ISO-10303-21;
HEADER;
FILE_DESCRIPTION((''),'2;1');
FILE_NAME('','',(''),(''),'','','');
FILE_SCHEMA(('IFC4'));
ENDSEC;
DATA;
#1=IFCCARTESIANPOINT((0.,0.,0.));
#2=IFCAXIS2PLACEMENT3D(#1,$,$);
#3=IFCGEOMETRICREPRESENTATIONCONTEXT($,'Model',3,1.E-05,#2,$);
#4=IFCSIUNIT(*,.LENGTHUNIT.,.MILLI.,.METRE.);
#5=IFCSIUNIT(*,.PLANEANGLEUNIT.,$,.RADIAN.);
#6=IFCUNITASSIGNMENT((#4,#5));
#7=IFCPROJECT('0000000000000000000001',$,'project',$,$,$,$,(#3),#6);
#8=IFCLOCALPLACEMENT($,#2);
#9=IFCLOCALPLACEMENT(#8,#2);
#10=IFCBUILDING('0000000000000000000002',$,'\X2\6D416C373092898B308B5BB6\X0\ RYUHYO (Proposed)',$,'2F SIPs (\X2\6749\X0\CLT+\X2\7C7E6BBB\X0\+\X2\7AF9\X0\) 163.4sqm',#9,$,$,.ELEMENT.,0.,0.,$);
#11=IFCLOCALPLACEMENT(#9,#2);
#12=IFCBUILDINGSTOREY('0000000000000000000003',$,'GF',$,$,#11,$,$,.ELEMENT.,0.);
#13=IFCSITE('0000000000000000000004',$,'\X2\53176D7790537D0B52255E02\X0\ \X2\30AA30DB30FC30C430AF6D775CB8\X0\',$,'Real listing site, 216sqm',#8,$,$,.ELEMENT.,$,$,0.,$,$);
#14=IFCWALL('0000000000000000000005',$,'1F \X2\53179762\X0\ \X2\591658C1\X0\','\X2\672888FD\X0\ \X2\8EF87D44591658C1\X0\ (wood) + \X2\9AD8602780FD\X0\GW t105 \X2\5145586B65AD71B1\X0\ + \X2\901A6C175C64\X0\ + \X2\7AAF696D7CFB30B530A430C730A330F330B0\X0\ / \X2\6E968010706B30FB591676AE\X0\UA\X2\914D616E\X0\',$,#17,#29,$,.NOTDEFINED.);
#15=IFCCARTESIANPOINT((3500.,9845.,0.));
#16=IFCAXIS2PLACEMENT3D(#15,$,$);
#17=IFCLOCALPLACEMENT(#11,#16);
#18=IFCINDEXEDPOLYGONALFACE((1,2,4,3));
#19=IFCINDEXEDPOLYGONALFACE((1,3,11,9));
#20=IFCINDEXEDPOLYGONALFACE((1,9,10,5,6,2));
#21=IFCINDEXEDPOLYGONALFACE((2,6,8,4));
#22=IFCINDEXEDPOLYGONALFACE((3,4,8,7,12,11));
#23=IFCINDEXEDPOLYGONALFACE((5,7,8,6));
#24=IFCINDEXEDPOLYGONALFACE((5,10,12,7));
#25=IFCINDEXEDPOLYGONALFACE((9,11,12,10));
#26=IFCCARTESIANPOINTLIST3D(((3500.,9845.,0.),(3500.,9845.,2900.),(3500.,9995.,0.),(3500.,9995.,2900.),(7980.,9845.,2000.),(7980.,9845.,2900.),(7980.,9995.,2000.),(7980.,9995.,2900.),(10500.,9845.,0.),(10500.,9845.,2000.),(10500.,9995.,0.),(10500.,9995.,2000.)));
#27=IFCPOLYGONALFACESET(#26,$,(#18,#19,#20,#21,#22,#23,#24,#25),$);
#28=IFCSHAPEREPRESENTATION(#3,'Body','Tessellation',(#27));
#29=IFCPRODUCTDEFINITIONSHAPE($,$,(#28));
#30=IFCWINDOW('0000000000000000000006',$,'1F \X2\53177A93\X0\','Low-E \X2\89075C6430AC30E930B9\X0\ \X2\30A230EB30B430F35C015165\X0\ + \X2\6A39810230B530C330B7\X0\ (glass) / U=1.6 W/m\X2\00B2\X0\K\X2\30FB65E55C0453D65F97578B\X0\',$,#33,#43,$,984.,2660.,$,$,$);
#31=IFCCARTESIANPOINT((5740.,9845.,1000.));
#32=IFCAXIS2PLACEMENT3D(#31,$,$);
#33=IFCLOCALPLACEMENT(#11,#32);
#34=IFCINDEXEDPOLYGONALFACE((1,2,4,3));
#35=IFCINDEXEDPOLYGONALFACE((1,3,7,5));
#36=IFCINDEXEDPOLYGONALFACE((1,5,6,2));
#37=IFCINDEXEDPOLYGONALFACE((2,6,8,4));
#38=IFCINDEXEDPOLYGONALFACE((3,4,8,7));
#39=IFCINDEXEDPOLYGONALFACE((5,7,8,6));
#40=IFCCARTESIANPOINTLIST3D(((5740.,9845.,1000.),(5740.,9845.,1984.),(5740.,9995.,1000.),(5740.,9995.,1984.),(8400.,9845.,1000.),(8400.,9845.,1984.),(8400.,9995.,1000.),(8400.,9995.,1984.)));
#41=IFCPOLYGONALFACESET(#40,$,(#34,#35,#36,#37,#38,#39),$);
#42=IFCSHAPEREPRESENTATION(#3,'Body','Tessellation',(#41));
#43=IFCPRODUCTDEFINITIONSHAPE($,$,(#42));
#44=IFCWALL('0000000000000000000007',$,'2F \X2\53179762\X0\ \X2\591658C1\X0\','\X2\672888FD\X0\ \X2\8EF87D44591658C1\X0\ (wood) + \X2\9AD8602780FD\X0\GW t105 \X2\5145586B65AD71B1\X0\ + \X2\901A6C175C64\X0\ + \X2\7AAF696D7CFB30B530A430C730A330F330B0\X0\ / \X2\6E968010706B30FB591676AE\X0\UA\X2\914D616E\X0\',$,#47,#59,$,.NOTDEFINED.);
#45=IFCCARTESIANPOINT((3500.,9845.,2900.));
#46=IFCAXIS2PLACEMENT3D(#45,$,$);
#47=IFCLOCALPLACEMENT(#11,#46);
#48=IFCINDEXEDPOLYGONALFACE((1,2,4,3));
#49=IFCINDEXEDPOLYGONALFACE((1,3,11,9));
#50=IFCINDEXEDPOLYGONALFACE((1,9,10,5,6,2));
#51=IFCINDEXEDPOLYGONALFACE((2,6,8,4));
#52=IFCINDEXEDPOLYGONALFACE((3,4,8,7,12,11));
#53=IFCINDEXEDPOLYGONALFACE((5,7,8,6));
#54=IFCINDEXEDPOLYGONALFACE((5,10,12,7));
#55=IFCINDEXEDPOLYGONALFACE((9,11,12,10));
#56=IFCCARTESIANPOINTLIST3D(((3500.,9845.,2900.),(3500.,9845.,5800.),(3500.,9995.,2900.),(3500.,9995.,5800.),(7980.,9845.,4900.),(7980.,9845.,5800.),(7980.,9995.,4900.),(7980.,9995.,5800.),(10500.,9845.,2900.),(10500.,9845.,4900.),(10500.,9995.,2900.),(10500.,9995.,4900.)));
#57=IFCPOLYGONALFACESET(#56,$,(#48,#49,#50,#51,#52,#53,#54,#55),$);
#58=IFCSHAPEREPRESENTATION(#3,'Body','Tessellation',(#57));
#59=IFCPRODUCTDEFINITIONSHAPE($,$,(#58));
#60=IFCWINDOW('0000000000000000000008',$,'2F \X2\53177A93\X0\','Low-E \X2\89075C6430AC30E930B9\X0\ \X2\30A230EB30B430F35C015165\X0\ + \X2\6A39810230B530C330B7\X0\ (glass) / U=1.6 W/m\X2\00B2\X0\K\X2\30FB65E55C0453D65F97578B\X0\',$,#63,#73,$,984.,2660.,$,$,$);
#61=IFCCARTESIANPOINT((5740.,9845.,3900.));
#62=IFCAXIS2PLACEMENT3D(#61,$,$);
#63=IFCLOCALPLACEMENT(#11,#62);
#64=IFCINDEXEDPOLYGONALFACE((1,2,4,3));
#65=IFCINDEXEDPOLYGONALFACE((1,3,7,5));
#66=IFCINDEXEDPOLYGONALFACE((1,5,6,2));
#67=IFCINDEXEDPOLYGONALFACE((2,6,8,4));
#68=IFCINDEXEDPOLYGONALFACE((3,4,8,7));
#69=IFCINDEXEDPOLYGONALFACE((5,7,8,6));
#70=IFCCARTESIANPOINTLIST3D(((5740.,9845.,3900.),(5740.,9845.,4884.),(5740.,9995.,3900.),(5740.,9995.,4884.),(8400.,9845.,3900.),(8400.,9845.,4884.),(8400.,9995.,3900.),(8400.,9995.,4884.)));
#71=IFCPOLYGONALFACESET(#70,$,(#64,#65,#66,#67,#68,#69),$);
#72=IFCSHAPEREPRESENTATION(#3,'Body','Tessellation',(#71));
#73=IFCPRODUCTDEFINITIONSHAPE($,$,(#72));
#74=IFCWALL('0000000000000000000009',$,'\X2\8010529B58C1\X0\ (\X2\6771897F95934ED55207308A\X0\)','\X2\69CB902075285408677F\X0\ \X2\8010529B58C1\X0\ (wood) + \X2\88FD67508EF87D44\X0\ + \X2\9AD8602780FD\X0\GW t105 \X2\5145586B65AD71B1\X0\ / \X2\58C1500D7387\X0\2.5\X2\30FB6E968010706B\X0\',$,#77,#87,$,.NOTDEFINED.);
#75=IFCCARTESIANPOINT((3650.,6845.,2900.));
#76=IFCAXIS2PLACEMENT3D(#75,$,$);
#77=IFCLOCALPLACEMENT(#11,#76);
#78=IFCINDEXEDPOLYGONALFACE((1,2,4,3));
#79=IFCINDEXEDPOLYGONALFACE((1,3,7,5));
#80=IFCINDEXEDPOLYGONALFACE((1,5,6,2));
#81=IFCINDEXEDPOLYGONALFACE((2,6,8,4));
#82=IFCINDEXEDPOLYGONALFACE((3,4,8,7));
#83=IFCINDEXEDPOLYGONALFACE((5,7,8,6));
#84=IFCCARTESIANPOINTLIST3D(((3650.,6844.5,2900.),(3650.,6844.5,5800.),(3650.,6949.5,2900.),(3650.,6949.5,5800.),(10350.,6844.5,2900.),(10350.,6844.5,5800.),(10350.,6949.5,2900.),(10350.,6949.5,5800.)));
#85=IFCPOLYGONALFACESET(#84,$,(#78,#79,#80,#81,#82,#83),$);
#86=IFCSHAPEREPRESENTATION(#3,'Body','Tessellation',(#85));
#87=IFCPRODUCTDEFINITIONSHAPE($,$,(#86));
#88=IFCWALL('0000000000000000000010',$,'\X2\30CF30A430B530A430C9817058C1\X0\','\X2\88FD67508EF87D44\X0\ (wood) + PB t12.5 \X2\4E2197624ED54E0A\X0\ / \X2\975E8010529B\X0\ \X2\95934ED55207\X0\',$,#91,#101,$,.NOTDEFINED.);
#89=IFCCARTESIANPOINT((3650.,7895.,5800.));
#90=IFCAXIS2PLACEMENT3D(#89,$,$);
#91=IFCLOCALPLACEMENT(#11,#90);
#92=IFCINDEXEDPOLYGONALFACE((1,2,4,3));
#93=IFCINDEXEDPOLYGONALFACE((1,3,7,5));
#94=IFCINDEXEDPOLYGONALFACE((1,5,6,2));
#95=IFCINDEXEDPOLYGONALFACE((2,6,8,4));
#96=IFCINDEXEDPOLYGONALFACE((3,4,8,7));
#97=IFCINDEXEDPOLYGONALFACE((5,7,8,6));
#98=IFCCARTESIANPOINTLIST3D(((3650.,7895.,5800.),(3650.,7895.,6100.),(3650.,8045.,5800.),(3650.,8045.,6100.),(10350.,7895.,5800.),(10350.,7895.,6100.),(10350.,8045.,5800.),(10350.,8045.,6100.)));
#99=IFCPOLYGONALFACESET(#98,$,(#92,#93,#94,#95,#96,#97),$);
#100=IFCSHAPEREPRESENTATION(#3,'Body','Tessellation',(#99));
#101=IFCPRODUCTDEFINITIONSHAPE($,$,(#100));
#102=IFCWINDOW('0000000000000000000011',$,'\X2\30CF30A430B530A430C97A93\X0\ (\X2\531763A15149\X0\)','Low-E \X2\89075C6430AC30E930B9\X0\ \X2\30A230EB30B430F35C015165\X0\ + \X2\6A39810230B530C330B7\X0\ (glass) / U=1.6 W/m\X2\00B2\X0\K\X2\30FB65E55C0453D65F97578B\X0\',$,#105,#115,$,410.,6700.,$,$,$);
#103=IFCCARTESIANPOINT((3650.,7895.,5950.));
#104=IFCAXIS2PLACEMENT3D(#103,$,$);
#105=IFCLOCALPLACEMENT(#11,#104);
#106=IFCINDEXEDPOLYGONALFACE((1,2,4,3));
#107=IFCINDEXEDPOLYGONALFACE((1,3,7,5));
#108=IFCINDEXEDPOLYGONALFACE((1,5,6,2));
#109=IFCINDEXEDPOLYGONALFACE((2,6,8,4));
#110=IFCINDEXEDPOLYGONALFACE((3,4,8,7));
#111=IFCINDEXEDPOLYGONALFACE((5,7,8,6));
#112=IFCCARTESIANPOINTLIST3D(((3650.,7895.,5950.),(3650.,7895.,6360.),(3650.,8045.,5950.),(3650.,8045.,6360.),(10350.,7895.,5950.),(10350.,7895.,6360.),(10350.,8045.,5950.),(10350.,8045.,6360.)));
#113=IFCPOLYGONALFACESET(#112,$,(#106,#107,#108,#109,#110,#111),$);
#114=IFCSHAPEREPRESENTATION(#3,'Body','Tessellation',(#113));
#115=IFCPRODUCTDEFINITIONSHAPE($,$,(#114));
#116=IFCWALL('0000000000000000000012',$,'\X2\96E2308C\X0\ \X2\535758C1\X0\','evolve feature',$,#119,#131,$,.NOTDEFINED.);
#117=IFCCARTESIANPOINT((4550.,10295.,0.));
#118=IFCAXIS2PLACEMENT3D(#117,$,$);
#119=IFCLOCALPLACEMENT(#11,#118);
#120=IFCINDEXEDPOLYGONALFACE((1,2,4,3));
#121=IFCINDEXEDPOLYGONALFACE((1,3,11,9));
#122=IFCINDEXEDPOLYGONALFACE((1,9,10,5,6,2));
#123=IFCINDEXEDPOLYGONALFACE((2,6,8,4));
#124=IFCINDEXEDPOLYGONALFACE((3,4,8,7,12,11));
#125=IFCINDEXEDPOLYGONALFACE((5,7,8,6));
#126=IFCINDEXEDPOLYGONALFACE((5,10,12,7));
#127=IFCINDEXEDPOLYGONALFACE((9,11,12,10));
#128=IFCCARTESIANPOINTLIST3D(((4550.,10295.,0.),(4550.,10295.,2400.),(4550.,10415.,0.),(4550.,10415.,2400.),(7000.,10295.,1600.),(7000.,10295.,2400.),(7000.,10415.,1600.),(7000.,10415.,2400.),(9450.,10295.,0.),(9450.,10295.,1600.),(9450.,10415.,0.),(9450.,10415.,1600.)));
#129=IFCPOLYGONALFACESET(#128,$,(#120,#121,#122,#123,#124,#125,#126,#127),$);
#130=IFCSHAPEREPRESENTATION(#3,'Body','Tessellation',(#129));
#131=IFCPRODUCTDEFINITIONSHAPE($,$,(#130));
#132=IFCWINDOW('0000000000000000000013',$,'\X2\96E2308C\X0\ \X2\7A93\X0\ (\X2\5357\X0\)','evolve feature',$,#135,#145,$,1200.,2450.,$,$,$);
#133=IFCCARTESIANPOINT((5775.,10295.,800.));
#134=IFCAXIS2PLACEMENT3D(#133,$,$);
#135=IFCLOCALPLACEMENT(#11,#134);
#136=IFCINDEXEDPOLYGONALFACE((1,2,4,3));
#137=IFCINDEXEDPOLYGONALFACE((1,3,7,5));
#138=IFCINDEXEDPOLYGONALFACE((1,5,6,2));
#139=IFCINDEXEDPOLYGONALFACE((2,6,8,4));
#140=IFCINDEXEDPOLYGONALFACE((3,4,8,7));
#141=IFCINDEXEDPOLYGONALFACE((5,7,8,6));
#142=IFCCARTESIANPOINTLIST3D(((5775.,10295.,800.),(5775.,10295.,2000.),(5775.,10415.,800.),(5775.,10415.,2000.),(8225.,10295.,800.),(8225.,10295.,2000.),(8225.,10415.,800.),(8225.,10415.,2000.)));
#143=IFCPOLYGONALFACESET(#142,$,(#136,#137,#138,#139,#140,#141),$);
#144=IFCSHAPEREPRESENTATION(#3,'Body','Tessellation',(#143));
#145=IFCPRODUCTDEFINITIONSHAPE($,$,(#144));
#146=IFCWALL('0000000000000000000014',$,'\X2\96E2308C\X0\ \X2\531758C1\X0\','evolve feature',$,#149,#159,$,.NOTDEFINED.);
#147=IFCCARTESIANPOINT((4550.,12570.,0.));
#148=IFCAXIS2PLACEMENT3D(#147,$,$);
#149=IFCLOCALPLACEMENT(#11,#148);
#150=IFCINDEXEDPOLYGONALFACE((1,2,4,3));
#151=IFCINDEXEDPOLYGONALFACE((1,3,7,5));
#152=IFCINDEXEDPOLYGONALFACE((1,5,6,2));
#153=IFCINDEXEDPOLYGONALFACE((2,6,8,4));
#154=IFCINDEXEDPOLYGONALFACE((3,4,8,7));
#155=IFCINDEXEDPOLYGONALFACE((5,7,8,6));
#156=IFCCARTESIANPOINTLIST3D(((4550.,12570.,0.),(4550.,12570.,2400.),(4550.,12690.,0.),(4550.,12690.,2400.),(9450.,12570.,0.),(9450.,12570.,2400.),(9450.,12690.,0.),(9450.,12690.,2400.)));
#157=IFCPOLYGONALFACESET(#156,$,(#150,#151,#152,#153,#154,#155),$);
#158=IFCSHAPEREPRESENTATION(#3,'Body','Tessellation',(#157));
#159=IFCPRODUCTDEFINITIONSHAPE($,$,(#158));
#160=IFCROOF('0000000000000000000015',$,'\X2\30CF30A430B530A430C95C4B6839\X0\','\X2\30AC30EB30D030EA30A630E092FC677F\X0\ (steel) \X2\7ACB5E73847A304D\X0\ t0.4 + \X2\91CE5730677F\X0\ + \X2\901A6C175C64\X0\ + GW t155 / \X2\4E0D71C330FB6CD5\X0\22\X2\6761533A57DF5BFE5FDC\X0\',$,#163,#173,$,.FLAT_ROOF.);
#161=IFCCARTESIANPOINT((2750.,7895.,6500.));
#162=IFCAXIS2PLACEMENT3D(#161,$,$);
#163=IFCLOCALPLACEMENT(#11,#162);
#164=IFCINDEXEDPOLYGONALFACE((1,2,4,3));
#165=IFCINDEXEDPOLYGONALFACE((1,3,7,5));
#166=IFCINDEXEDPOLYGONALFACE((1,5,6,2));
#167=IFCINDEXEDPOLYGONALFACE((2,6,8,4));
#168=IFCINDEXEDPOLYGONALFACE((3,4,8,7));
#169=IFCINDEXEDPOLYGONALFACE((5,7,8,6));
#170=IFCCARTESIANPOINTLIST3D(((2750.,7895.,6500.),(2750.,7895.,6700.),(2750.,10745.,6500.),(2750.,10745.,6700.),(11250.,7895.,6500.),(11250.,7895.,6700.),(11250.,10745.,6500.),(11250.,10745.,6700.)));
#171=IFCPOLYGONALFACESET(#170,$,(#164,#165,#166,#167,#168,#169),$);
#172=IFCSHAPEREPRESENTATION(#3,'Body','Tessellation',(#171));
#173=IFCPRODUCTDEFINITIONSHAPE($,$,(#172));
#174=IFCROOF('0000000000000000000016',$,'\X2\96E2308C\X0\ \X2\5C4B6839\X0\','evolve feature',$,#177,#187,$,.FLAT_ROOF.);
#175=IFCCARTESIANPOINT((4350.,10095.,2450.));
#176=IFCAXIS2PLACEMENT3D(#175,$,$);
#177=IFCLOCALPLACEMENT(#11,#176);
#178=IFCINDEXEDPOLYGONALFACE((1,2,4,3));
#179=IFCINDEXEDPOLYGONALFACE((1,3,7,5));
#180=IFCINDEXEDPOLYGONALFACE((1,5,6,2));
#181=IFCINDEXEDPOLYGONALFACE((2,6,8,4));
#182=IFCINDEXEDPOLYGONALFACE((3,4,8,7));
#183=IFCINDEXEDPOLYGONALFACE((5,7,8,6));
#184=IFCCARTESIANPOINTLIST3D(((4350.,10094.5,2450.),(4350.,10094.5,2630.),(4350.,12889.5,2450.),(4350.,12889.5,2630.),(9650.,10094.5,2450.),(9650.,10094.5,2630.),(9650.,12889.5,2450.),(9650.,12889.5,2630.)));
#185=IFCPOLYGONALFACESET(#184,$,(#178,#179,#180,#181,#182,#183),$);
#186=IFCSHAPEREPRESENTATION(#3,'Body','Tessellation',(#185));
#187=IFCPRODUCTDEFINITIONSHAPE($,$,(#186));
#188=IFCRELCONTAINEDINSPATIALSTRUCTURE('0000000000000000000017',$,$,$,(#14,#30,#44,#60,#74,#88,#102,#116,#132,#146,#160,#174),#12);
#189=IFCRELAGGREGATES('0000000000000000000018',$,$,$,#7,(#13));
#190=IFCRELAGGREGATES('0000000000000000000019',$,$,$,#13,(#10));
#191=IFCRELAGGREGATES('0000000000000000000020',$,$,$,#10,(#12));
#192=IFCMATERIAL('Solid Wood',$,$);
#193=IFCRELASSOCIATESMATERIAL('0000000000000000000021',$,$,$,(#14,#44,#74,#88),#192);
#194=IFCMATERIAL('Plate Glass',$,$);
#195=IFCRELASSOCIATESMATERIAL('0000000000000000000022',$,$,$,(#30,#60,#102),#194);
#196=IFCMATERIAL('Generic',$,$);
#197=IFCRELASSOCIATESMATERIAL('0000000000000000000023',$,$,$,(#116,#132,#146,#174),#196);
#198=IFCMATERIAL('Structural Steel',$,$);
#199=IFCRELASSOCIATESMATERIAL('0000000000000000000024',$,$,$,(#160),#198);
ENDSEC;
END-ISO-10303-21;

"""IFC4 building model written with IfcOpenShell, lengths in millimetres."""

from ifc_helpers import new_model, si_unit, frame, frame_2d, origin, place, context, project, spatial, rectangle, extrude, material, element, fill, save


model = new_model("IFC4")

# Units and contexts
model_context = context("Model", 3, precision=1e-05, world=origin())
ifc_project = project(units=[si_unit("LENGTHUNIT", "METRE", prefix="MILLI"), si_unit("PLANEANGLEUNIT", "RADIAN")], contexts=[model_context])

# Site, building, storey
site_placement = place(None, origin())
site = spatial("IfcSite", under=ifc_project, at=site_placement, Name="北海道紋別市 オホーツク海岸", ObjectType="Real listing site, 216sqm", CompositionType="ELEMENT", RefElevation=0.0)
building_placement = place(site_placement, origin())
building = spatial("IfcBuilding", under=site, at=building_placement, Name="流氷を見る家 RYUHYO (Proposed)", ObjectType="2F SIPs (杉CLT+籾殻+竹) 163.4sqm", CompositionType="ELEMENT", ElevationOfRefHeight=0.0, ElevationOfTerrain=0.0)
storey_placement = place(building_placement, origin())
storey = spatial("IfcBuildingStorey", under=building, at=storey_placement, Name="GF", CompositionType="ELEMENT", Elevation=0.0)

# Shared definitions
ifc_material_1 = material(Name="Generic")

# Wall, opening, window
ifc_material_2 = material(Name="Solid Wood")
wall_1_placement = place(storey_placement, frame((3500.0, 9845.0, 0.0)))
wall_1 = element("IfcWall", 1, at=wall_1_placement, inside=storey, material=ifc_material_2, Name="1F 北面 外壁", Description="木製 軸組外壁 (wood) + 高性能GW t105 充填断熱 + 通気層 + 窯業系サイディング / 準耐火・外皮UA配慮", PredefinedType="NOTDEFINED", context=model_context, shape_type="SweptSolid", body=[
    extrude(rectangle(XDim=7000.0, YDim=150.0, at=frame_2d((3500.0, 75.0))), frame((3500.0, 9845.0, 0.0)), (0.0, 0.0, 1.0), 2900.0),
])
opening_1_placement = place(storey_placement, frame((5740.0, 9845.0, 1000.0)))
opening_1 = element("IfcOpeningElement", 2, at=opening_1_placement, cuts=wall_1, PredefinedType="NOTDEFINED", context=model_context, shape_type="SweptSolid", body=[
    extrude(rectangle(XDim=2660.0, YDim=150.0, at=frame_2d((1330.0, 75.0))), frame((5740.0, 9845.0, 1000.0)), (0.0, 0.0, 1.0), 984.0),
])
ifc_material_3 = material(Name="Plate Glass")
window_1_placement = place(storey_placement, frame((5740.0, 9845.0, 1000.0)))
window_1 = element("IfcWindow", 3, at=window_1_placement, inside=storey, material=ifc_material_3, Name="1F 北窓", Description="Low-E 複層ガラス アルゴン封入 + 樹脂サッシ (glass) / U=1.6 W/m²K・日射取得型", OverallHeight=984.0, OverallWidth=2660.0, context=model_context, shape_type="SweptSolid", body=[
    extrude(rectangle(XDim=2660.0, YDim=150.0, at=frame_2d((1330.0, 75.0))), frame((5740.0, 9845.0, 1000.0)), (0.0, 0.0, 1.0), 984.0),
])
fill(opening_1, window_1)

# Wall, opening, window
wall_2_placement = place(storey_placement, frame((3500.0, 9845.0, 2900.0)))
wall_2 = element("IfcWall", 4, at=wall_2_placement, inside=storey, material=ifc_material_2, Name="2F 北面 外壁", Description="木製 軸組外壁 (wood) + 高性能GW t105 充填断熱 + 通気層 + 窯業系サイディング / 準耐火・外皮UA配慮", PredefinedType="NOTDEFINED", context=model_context, shape_type="SweptSolid", body=[
    extrude(rectangle(XDim=7000.0, YDim=150.0, at=frame_2d((3500.0, 75.0))), frame((3500.0, 9845.0, 2900.0)), (0.0, 0.0, 1.0), 2900.0),
])
opening_2_placement = place(storey_placement, frame((5740.0, 9845.0, 3900.0)))
opening_2 = element("IfcOpeningElement", 5, at=opening_2_placement, cuts=wall_2, PredefinedType="NOTDEFINED", context=model_context, shape_type="SweptSolid", body=[
    extrude(rectangle(XDim=2660.0, YDim=150.0, at=frame_2d((1330.0, 75.0))), frame((5740.0, 9845.0, 3900.0)), (0.0, 0.0, 1.0), 984.0),
])
window_2_placement = place(storey_placement, frame((5740.0, 9845.0, 3900.0)))
window_2 = element("IfcWindow", 6, at=window_2_placement, inside=storey, material=ifc_material_3, Name="2F 北窓", Description="Low-E 複層ガラス アルゴン封入 + 樹脂サッシ (glass) / U=1.6 W/m²K・日射取得型", OverallHeight=984.0, OverallWidth=2660.0, context=model_context, shape_type="SweptSolid", body=[
    extrude(rectangle(XDim=2660.0, YDim=150.0, at=frame_2d((1330.0, 75.0))), frame((5740.0, 9845.0, 3900.0)), (0.0, 0.0, 1.0), 984.0),
])
fill(opening_2, window_2)

# Wall
wall_3_placement = place(storey_placement, frame((3650.0, 6845.0, 2900.0)))
element("IfcWall", 7, at=wall_3_placement, inside=storey, material=ifc_material_2, Name="耐力壁 (東西間仕切り)", Description="構造用合板 耐力壁 (wood) + 製材軸組 + 高性能GW t105 充填断熱 / 壁倍率2.5・準耐火", PredefinedType="NOTDEFINED", context=model_context, shape_type="SweptSolid", body=[
    extrude(rectangle(XDim=6700.0, YDim=105.0, at=frame_2d((3350.0, 52.0))), frame((3650.0, 6845.0, 2900.0)), (0.0, 0.0, 1.0), 2900.0),
])

# Walls, openings, windows
wall_4_placement = place(storey_placement, frame((3650.0, 7895.0, 5800.0)))
wall_4 = element("IfcWall", 8, at=wall_4_placement, inside=storey, material=ifc_material_2, Name="ハイサイド腰壁", Description="製材軸組 (wood) + PB t12.5 両面仕上 / 非耐力 間仕切", PredefinedType="NOTDEFINED", context=model_context, shape_type="SweptSolid", body=[
    extrude(rectangle(XDim=6700.0, YDim=150.0, at=frame_2d((3350.0, 75.0))), frame((3650.0, 7895.0, 5800.0)), (0.0, 0.0, 1.0), 700.0),
])
opening_3_placement = place(storey_placement, frame((3650.0, 7895.0, 5950.0)))
opening_3 = element("IfcOpeningElement", 9, at=opening_3_placement, cuts=wall_4, PredefinedType="NOTDEFINED", context=model_context, shape_type="SweptSolid", body=[
    extrude(rectangle(XDim=6700.0, YDim=150.0, at=frame_2d((3350.0, 75.0))), frame((3650.0, 7895.0, 5950.0)), (0.0, 0.0, 1.0), 410.0),
])
window_3_placement = place(storey_placement, frame((3650.0, 7895.0, 5950.0)))
window_3 = element("IfcWindow", 10, at=window_3_placement, inside=storey, material=ifc_material_3, Name="ハイサイド窓 (北採光)", Description="Low-E 複層ガラス アルゴン封入 + 樹脂サッシ (glass) / U=1.6 W/m²K・日射取得型", OverallHeight=410.0, OverallWidth=6700.0, context=model_context, shape_type="SweptSolid", body=[
    extrude(rectangle(XDim=6700.0, YDim=150.0, at=frame_2d((3350.0, 75.0))), frame((3650.0, 7895.0, 5950.0)), (0.0, 0.0, 1.0), 410.0),
])
fill(opening_3, window_3)
wall_5_placement = place(storey_placement, frame((4550.0, 10295.0, 0.0)))
wall_5 = element("IfcWall", 11, at=wall_5_placement, inside=storey, material=ifc_material_1, Name="離れ 南壁", Description="evolve feature", PredefinedType="NOTDEFINED", context=model_context, shape_type="SweptSolid", body=[
    extrude(rectangle(XDim=4900.0, YDim=120.0, at=frame_2d((2450.0, 60.0))), frame((4550.0, 10295.0, 0.0)), (0.0, 0.0, 1.0), 2400.0),
])
opening_4_placement = place(storey_placement, frame((5775.0, 10295.0, 800.0)))
opening_4 = element("IfcOpeningElement", 12, at=opening_4_placement, cuts=wall_5, PredefinedType="NOTDEFINED", context=model_context, shape_type="SweptSolid", body=[
    extrude(rectangle(XDim=2450.0, YDim=120.0, at=frame_2d((1225.0, 60.0))), frame((5775.0, 10295.0, 800.0)), (0.0, 0.0, 1.0), 1200.0),
])
window_4_placement = place(storey_placement, frame((5775.0, 10295.0, 800.0)))
window_4 = element("IfcWindow", 13, at=window_4_placement, inside=storey, material=ifc_material_1, Name="離れ 窓 (南)", Description="evolve feature", OverallHeight=1200.0, OverallWidth=2450.0, context=model_context, shape_type="SweptSolid", body=[
    extrude(rectangle(XDim=2450.0, YDim=120.0, at=frame_2d((1225.0, 60.0))), frame((5775.0, 10295.0, 800.0)), (0.0, 0.0, 1.0), 1200.0),
])
fill(opening_4, window_4)

# Wall
wall_6_placement = place(storey_placement, frame((4550.0, 12570.0, 0.0)))
element("IfcWall", 14, at=wall_6_placement, inside=storey, material=ifc_material_1, Name="離れ 北壁", Description="evolve feature", PredefinedType="NOTDEFINED", context=model_context, shape_type="SweptSolid", body=[
    extrude(rectangle(XDim=4900.0, YDim=120.0, at=frame_2d((2450.0, 60.0))), frame((4550.0, 12570.0, 0.0)), (0.0, 0.0, 1.0), 2400.0),
])

# Roofs
ifc_material_4 = material(Name="Structural Steel")
roof_1_placement = place(storey_placement, frame((2750.0, 7895.0, 6500.0)))
element("IfcRoof", 15, at=roof_1_placement, inside=storey, material=ifc_material_4, Name="ハイサイド屋根", Description="ガルバリウム鋼板 (steel) 立平葺き t0.4 + 野地板 + 通気層 + GW t155 / 不燃・法22条区域対応", PredefinedType="FLAT_ROOF", context=model_context, shape_type="SweptSolid", body=[
    extrude(rectangle(XDim=8500.0, YDim=2850.0, at=frame_2d((4250.0, 1425.0))), frame((2750.0, 7895.0, 6500.0)), (0.0, 0.0, 1.0), 200.0),
])
roof_2_placement = place(storey_placement, frame((4350.0, 10095.0, 2450.0)))
element("IfcRoof", 16, at=roof_2_placement, inside=storey, material=ifc_material_1, Name="離れ 屋根", Description="evolve feature", PredefinedType="FLAT_ROOF", context=model_context, shape_type="SweptSolid", body=[
    extrude(rectangle(XDim=5300.0, YDim=2795.0, at=frame_2d((2650.0, 1397.0))), frame((4350.0, 10095.0, 2450.0)), (0.0, 0.0, 1.0), 180.0),
])

save(model, "model.ifc")
